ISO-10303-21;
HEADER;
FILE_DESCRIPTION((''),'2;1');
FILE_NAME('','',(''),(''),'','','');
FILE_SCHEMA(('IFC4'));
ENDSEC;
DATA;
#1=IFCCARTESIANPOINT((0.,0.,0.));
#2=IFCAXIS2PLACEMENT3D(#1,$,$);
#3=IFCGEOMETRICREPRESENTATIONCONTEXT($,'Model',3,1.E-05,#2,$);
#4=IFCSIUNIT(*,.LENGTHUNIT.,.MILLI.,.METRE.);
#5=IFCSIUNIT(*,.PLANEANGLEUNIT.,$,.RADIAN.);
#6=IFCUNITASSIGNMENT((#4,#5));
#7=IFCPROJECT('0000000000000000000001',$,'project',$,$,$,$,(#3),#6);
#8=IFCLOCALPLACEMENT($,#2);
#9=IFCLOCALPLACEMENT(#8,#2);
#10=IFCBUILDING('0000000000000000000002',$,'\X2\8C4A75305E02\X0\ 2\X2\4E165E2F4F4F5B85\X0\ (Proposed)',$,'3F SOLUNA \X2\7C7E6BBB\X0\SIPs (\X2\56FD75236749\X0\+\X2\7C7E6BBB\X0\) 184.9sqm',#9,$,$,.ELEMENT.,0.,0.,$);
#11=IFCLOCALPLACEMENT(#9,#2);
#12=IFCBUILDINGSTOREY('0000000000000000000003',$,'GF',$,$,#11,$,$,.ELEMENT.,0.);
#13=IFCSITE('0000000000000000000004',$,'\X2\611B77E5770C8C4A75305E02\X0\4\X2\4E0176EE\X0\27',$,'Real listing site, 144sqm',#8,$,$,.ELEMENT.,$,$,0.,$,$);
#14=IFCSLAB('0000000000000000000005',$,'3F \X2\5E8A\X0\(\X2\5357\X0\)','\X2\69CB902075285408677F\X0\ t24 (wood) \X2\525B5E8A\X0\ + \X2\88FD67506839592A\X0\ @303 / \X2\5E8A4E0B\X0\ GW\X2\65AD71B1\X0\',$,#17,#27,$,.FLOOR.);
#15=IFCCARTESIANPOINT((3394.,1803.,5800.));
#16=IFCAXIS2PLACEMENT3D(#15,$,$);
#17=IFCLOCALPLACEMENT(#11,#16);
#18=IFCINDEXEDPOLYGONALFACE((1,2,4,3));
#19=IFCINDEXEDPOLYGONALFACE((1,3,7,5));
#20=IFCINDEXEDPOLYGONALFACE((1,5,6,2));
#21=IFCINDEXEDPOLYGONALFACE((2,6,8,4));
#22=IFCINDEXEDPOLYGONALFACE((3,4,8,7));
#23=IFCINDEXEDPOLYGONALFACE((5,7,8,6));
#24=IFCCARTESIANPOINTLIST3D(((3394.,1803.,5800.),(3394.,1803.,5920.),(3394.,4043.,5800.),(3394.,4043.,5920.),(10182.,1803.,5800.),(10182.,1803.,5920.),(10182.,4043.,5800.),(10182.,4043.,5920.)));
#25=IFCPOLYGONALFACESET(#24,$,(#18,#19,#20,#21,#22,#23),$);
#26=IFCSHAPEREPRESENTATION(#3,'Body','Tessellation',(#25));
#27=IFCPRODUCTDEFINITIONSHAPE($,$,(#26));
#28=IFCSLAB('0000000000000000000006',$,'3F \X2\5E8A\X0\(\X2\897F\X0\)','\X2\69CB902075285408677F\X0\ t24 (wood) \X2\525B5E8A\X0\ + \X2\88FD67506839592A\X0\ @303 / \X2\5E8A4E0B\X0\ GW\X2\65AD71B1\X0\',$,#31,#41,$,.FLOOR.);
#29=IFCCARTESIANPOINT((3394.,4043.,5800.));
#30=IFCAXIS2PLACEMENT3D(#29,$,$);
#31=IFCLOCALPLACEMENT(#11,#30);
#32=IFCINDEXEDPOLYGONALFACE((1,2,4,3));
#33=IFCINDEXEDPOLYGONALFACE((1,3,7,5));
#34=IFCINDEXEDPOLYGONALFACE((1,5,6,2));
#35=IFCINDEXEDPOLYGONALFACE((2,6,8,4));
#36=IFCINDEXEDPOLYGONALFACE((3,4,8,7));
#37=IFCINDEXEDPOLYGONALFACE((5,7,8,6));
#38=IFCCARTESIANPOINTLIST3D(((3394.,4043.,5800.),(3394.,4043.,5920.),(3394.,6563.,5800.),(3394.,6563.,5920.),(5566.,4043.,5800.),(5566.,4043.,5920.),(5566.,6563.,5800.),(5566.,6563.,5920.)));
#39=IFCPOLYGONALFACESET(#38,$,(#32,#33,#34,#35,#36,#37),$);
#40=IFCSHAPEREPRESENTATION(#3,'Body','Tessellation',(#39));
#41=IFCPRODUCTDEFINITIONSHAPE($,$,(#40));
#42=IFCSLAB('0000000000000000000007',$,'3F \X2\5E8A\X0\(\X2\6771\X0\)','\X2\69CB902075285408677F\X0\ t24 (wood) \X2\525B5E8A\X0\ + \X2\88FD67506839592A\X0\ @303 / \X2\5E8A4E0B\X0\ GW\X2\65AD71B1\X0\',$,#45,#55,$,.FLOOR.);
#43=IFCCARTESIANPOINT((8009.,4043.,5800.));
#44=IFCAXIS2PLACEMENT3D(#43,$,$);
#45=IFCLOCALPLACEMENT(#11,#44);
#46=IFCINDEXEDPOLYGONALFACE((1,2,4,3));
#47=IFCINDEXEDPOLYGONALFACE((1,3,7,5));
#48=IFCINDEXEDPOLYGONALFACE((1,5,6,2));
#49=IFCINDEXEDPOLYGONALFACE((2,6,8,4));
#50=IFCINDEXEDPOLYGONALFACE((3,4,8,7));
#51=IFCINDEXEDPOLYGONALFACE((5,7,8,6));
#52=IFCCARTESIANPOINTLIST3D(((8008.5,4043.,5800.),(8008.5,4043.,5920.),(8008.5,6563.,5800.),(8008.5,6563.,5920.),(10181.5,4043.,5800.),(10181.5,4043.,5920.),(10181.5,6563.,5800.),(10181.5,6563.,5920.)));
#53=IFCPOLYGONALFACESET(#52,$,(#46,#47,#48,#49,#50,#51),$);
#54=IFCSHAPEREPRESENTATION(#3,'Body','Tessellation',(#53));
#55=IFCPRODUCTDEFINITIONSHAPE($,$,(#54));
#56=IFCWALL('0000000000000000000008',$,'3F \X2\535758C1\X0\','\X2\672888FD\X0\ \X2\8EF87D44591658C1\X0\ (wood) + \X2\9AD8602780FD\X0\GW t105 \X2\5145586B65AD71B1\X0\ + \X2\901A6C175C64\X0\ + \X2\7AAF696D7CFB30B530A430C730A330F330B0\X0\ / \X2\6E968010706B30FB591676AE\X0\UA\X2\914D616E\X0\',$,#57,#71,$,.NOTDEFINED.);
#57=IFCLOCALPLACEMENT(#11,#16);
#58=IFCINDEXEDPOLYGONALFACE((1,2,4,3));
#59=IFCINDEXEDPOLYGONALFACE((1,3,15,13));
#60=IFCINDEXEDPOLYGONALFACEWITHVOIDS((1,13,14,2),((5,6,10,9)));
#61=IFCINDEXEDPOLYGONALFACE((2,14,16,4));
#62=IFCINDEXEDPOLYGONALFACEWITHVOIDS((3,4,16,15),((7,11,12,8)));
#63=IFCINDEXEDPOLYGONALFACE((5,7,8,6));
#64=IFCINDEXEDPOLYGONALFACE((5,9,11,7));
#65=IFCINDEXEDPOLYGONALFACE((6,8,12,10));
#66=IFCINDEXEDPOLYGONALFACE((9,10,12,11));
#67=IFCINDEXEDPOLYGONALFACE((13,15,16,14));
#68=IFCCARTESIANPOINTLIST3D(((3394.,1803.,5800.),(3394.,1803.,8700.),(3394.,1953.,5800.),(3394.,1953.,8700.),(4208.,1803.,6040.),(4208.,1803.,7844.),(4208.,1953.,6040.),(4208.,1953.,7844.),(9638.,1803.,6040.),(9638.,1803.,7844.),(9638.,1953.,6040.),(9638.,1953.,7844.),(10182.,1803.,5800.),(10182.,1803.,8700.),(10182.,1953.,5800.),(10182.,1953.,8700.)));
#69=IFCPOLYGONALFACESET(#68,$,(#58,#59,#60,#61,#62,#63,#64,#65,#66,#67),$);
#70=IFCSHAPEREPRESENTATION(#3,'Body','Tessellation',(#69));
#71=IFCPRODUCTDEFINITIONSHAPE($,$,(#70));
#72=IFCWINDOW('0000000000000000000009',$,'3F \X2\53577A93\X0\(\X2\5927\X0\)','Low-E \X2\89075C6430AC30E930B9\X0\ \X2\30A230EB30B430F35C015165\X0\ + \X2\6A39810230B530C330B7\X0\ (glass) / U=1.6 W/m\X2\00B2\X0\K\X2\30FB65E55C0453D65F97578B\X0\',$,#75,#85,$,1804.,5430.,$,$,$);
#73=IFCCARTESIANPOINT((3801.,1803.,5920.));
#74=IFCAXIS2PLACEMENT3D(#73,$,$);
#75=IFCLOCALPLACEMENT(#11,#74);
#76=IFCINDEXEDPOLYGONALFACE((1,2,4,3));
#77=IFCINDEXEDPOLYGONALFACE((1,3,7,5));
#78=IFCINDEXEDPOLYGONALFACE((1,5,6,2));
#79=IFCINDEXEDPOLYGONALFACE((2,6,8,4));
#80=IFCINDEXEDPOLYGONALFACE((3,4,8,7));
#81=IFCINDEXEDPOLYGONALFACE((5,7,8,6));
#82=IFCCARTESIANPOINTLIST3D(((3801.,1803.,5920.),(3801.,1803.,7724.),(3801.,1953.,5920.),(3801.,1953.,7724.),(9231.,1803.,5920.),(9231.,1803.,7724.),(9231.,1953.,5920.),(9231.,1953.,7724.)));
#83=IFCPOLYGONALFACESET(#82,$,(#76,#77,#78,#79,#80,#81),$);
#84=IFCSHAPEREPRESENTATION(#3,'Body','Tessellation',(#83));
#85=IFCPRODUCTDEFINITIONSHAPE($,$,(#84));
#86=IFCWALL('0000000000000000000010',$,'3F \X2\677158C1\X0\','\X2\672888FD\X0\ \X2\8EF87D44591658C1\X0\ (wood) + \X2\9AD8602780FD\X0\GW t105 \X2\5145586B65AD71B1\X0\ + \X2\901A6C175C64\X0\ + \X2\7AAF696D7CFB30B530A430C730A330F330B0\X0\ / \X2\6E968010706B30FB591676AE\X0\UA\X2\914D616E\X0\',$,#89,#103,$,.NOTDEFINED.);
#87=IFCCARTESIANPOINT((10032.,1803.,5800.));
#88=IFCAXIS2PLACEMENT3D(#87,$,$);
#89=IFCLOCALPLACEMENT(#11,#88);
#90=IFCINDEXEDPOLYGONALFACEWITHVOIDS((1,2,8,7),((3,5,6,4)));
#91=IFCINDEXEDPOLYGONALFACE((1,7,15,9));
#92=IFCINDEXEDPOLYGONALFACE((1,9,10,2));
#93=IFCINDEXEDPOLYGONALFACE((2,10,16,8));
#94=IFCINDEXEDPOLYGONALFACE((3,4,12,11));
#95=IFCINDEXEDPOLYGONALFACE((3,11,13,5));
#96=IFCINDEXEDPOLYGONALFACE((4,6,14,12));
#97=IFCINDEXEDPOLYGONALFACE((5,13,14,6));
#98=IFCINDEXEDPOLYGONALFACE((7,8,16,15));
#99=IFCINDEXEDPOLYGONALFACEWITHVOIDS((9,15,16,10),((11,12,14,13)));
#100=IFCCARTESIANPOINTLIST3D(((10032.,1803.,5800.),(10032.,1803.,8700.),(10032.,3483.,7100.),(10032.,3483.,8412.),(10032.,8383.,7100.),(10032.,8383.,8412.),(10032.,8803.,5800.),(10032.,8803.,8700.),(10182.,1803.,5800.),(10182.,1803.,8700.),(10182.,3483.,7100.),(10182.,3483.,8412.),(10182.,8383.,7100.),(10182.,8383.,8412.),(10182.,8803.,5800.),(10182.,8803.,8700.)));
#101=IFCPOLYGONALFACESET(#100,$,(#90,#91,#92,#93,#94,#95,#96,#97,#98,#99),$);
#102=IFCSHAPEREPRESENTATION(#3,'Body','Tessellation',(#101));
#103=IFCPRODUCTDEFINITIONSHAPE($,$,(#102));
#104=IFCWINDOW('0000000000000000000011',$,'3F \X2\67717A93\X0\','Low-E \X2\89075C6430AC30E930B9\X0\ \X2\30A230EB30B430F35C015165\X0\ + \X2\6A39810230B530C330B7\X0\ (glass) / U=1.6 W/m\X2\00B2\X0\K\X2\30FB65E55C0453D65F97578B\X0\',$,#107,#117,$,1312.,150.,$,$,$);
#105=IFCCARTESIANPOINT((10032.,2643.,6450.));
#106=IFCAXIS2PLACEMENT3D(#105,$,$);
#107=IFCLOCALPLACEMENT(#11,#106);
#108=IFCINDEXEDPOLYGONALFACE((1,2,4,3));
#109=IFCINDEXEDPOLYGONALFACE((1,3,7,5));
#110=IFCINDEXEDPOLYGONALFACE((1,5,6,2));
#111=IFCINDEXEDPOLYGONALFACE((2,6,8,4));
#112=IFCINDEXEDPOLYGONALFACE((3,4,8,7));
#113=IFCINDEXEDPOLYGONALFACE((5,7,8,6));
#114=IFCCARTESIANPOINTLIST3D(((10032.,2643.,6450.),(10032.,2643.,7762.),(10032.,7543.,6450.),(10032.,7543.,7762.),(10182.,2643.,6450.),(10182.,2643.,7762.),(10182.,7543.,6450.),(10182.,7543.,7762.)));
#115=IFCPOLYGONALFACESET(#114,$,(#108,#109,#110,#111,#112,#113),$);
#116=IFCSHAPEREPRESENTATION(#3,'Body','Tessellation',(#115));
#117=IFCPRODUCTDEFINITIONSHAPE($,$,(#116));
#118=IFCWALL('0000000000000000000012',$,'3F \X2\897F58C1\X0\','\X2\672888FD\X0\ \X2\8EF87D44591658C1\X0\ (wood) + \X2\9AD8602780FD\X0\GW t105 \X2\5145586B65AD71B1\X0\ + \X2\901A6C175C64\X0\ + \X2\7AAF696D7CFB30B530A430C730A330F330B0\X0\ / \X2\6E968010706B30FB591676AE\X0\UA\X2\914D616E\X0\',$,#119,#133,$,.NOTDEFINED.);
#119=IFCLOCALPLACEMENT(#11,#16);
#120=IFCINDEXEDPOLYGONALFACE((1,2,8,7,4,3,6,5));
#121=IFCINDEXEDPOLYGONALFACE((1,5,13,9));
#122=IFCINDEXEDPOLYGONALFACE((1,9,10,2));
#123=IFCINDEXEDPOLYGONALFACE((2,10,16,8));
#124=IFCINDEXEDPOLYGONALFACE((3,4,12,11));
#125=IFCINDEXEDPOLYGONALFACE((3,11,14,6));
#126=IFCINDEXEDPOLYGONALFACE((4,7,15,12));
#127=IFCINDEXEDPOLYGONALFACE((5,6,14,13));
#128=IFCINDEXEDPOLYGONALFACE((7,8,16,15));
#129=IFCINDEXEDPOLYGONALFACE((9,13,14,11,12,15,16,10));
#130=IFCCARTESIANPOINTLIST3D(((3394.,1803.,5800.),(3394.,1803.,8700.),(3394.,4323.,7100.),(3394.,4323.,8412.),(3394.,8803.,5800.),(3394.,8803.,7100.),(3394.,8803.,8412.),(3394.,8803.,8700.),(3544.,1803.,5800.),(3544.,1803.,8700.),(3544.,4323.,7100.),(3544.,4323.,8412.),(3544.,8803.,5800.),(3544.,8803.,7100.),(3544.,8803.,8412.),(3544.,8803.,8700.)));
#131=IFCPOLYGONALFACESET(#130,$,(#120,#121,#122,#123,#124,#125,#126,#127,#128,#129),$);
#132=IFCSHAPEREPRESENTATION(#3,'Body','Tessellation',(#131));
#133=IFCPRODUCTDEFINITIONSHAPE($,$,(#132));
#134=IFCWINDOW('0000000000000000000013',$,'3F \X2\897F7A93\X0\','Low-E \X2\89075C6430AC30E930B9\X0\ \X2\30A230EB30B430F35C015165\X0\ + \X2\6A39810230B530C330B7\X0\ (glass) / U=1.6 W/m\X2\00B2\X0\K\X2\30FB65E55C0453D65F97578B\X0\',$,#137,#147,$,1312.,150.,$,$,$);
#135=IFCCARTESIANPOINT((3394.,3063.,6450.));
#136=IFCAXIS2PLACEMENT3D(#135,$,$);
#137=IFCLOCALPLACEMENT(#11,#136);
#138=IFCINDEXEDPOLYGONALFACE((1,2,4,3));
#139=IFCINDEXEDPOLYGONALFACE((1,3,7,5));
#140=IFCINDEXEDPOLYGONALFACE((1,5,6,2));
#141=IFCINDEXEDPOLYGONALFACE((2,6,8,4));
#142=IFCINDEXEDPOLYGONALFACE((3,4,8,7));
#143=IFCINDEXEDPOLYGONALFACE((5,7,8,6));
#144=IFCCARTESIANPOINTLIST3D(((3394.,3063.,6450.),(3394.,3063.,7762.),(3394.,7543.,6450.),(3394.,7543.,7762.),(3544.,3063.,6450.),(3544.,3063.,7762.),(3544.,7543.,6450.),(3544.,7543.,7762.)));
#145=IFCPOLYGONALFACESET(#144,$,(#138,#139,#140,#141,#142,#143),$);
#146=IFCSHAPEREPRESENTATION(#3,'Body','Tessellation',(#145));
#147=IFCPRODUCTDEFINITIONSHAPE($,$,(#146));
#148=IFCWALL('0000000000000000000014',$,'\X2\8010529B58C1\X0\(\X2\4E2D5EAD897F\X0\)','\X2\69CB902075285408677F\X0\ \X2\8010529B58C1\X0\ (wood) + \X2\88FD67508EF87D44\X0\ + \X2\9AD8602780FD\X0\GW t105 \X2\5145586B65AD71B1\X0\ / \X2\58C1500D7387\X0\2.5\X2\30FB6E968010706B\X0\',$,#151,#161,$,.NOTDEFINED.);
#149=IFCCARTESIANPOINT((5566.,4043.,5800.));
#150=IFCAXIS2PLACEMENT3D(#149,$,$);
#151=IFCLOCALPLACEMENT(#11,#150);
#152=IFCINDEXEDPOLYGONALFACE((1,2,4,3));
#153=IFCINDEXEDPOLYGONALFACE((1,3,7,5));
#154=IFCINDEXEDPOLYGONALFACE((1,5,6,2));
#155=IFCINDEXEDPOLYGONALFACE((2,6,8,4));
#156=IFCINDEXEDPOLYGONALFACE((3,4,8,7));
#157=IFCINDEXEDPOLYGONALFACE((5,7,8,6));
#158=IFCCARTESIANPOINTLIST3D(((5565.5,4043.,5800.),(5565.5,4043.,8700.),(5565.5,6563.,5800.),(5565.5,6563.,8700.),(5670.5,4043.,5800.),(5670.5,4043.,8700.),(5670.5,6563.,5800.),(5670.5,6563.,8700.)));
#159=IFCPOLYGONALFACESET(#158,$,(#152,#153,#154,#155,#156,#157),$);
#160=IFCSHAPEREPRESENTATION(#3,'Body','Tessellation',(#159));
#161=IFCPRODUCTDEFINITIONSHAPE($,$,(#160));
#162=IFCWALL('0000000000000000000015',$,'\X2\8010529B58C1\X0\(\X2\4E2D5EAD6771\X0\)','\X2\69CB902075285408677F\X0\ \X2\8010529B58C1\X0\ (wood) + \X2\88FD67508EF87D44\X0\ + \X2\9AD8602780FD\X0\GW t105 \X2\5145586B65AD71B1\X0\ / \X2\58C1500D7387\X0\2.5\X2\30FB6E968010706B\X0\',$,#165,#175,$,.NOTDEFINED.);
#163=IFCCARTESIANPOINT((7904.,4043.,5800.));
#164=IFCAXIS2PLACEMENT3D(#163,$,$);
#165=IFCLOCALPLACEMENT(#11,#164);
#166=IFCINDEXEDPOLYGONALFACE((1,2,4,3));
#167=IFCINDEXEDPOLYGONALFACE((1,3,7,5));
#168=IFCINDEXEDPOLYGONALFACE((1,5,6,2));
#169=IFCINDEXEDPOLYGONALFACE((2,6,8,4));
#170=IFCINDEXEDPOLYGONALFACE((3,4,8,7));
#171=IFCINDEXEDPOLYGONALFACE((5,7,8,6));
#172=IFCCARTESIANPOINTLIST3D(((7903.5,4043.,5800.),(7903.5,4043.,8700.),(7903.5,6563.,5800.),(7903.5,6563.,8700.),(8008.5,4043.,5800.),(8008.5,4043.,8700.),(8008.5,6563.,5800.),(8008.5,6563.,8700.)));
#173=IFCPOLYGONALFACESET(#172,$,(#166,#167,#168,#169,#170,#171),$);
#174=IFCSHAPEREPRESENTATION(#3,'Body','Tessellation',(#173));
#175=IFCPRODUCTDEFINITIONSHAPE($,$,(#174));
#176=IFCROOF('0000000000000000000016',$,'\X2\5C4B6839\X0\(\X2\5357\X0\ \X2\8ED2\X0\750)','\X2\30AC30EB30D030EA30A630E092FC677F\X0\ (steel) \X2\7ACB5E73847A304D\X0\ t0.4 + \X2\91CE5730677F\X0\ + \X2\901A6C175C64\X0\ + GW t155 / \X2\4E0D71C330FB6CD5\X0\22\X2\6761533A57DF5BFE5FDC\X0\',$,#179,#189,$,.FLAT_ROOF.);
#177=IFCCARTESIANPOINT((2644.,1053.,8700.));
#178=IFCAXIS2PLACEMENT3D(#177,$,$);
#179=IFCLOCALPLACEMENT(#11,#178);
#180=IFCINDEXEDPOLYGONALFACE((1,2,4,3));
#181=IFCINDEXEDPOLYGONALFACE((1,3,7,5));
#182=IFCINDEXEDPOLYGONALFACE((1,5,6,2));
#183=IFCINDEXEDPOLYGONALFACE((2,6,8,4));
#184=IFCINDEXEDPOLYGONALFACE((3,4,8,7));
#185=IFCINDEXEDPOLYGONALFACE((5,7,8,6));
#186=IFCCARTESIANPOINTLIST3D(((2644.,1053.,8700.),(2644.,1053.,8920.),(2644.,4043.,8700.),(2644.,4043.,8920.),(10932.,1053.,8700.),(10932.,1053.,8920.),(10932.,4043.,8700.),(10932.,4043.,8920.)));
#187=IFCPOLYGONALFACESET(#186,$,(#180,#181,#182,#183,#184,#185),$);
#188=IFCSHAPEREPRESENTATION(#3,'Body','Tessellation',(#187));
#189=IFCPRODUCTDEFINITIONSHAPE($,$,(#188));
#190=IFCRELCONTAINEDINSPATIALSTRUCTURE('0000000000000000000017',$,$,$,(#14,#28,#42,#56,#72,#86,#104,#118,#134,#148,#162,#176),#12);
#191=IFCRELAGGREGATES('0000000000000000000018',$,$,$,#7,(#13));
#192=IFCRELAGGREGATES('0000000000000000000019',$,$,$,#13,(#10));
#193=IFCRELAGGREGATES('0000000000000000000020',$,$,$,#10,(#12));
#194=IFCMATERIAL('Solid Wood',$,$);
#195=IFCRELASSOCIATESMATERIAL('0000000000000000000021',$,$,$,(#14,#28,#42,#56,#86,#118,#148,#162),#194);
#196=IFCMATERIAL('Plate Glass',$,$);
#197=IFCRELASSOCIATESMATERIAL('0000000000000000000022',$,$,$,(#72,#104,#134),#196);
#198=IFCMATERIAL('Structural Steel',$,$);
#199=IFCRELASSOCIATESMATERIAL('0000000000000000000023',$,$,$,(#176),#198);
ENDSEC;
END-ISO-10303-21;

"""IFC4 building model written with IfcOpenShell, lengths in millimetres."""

from ifc_helpers import new_model, si_unit, frame, frame_2d, origin, place, context, project, spatial, rectangle, extrude, material, element, fill, save


model = new_model("IFC4")

# Units and contexts
model_context = context("Model", 3, precision=1e-05, world=origin())
ifc_project = project(units=[si_unit("LENGTHUNIT", "METRE", prefix="MILLI"), si_unit("PLANEANGLEUNIT", "RADIAN")], contexts=[model_context])

# Site, building, storey
site_placement = place(None, origin())
site = spatial("IfcSite", under=ifc_project, at=site_placement, Name="愛知県豊田市4丁目27", ObjectType="Real listing site, 144sqm", CompositionType="ELEMENT", RefElevation=0.0)
building_placement = place(site_placement, origin())
building = spatial("IfcBuilding", under=site, at=building_placement, Name="豊田市 2世帯住宅 (Proposed)", ObjectType="3F SOLUNA 籾殻SIPs (国産杉+籾殻) 184.9sqm", CompositionType="ELEMENT", ElevationOfRefHeight=0.0, ElevationOfTerrain=0.0)
storey_placement = place(building_placement, origin())
storey = spatial("IfcBuildingStorey", under=building, at=storey_placement, Name="GF", CompositionType="ELEMENT", Elevation=0.0)

# Slabs
ifc_material_1 = material(Name="Solid Wood")
slab_1_placement = place(storey_placement, frame((3394.0, 1803.0, 5800.0)))
element("IfcSlab", 1, at=slab_1_placement, inside=storey, material=ifc_material_1, Name="3F 床(南)", Description="構造用合板 t24 (wood) 剛床 + 製材根太 @303 / 床下 GW断熱", PredefinedType="FLOOR", context=model_context, shape_type="SweptSolid", body=[
    extrude(rectangle(XDim=6788.0, YDim=2240.0, at=frame_2d((3394.0, 1120.0))), frame((3394.0, 1803.0, 5800.0)), (0.0, 0.0, 1.0), 120.0),
])
slab_2_placement = place(storey_placement, frame((3394.0, 4043.0, 5800.0)))
element("IfcSlab", 2, at=slab_2_placement, inside=storey, material=ifc_material_1, Name="3F 床(西)", Description="構造用合板 t24 (wood) 剛床 + 製材根太 @303 / 床下 GW断熱", PredefinedType="FLOOR", context=model_context, shape_type="SweptSolid", body=[
    extrude(rectangle(XDim=2172.0, YDim=2520.0, at=frame_2d((1086.0, 1260.0))), frame((3394.0, 4043.0, 5800.0)), (0.0, 0.0, 1.0), 120.0),
])
slab_3_placement = place(storey_placement, frame((8009.0, 4043.0, 5800.0)))
element("IfcSlab", 3, at=slab_3_placement, inside=storey, material=ifc_material_1, Name="3F 床(東)", Description="構造用合板 t24 (wood) 剛床 + 製材根太 @303 / 床下 GW断熱", PredefinedType="FLOOR", context=model_context, shape_type="SweptSolid", body=[
    extrude(rectangle(XDim=2173.0, YDim=2520.0, at=frame_2d((1086.0, 1260.0))), frame((8009.0, 4043.0, 5800.0)), (0.0, 0.0, 1.0), 120.0),
])

# Walls, openings, windows
wall_1_placement = place(storey_placement, frame((3394.0, 1803.0, 5800.0)))
wall_1 = element("IfcWall", 4, at=wall_1_placement, inside=storey, material=ifc_material_1, Name="3F 南壁", Description="木製 軸組外壁 (wood) + 高性能GW t105 充填断熱 + 通気層 + 窯業系サイディング / 準耐火・外皮UA配慮", PredefinedType="NOTDEFINED", context=model_context, shape_type="SweptSolid", body=[
    extrude(rectangle(XDim=6788.0, YDim=150.0, at=frame_2d((3394.0, 75.0))), frame((3394.0, 1803.0, 5800.0)), (0.0, 0.0, 1.0), 2900.0),
])
opening_1_placement = place(storey_placement, frame((3801.0, 1803.0, 5920.0)))
opening_1 = element("IfcOpeningElement", 5, at=opening_1_placement, cuts=wall_1, PredefinedType="NOTDEFINED", context=model_context, shape_type="SweptSolid", body=[
    extrude(rectangle(XDim=5430.0, YDim=150.0, at=frame_2d((2715.0, 75.0))), frame((3801.0, 1803.0, 5920.0)), (0.0, 0.0, 1.0), 1804.0),
])
ifc_material_2 = material(Name="Plate Glass")
window_1_placement = place(storey_placement, frame((3801.0, 1803.0, 5920.0)))
window_1 = element("IfcWindow", 6, at=window_1_placement, inside=storey, material=ifc_material_2, Name="3F 南窓(大)", Description="Low-E 複層ガラス アルゴン封入 + 樹脂サッシ (glass) / U=1.6 W/m²K・日射取得型", OverallHeight=1804.0, OverallWidth=5430.0, context=model_context, shape_type="SweptSolid", body=[
    extrude(rectangle(XDim=5430.0, YDim=150.0, at=frame_2d((2715.0, 75.0))), frame((3801.0, 1803.0, 5920.0)), (0.0, 0.0, 1.0), 1804.0),
])
fill(opening_1, window_1)
wall_2_placement = place(storey_placement, frame((10032.0, 1803.0, 5800.0)))
wall_2 = element("IfcWall", 7, at=wall_2_placement, inside=storey, material=ifc_material_1, Name="3F 東壁", Description="木製 軸組外壁 (wood) + 高性能GW t105 充填断熱 + 通気層 + 窯業系サイディング / 準耐火・外皮UA配慮", PredefinedType="NOTDEFINED", context=model_context, shape_type="SweptSolid", body=[
    extrude(rectangle(XDim=150.0, YDim=7000.0, at=frame_2d((75.0, 3500.0))), frame((10032.0, 1803.0, 5800.0)), (0.0, 0.0, 1.0), 2900.0),
])
opening_2_placement = place(storey_placement, frame((10032.0, 2643.0, 6450.0)))
opening_2 = element("IfcOpeningElement", 8, at=opening_2_placement, cuts=wall_2, PredefinedType="NOTDEFINED", context=model_context, shape_type="SweptSolid", body=[
    extrude(rectangle(XDim=150.0, YDim=4900.0, at=frame_2d((75.0, 2450.0))), frame((10032.0, 2643.0, 6450.0)), (0.0, 0.0, 1.0), 1312.0),
])
window_2_placement = place(storey_placement, frame((10032.0, 2643.0, 6450.0)))
window_2 = element("IfcWindow", 9, at=window_2_placement, inside=storey, material=ifc_material_2, Name="3F 東窓", Description="Low-E 複層ガラス アルゴン封入 + 樹脂サッシ (glass) / U=1.6 W/m²K・日射取得型", OverallHeight=1312.0, OverallWidth=150.0, context=model_context, shape_type="SweptSolid", body=[
    extrude(rectangle(XDim=150.0, YDim=4900.0, at=frame_2d((75.0, 2450.0))), frame((10032.0, 2643.0, 6450.0)), (0.0, 0.0, 1.0), 1312.0),
])
fill(opening_2, window_2)
wall_3_placement = place(storey_placement, frame((3394.0, 1803.0, 5800.0)))
wall_3 = element("IfcWall", 10, at=wall_3_placement, inside=storey, material=ifc_material_1, Name="3F 西壁", Description="木製 軸組外壁 (wood) + 高性能GW t105 充填断熱 + 通気層 + 窯業系サイディング / 準耐火・外皮UA配慮", PredefinedType="NOTDEFINED", context=model_context, shape_type="SweptSolid", body=[
    extrude(rectangle(XDim=150.0, YDim=7000.0, at=frame_2d((75.0, 3500.0))), frame((3394.0, 1803.0, 5800.0)), (0.0, 0.0, 1.0), 2900.0),
])
opening_3_placement = place(storey_placement, frame((3394.0, 3063.0, 6450.0)))
opening_3 = element("IfcOpeningElement", 11, at=opening_3_placement, cuts=wall_3, PredefinedType="NOTDEFINED", context=model_context, shape_type="SweptSolid", body=[
    extrude(rectangle(XDim=150.0, YDim=4480.0, at=frame_2d((75.0, 2240.0))), frame((3394.0, 3063.0, 6450.0)), (0.0, 0.0, 1.0), 1312.0),
])
window_3_placement = place(storey_placement, frame((3394.0, 3063.0, 6450.0)))
window_3 = element("IfcWindow", 12, at=window_3_placement, inside=storey, material=ifc_material_2, Name="3F 西窓", Description="Low-E 複層ガラス アルゴン封入 + 樹脂サッシ (glass) / U=1.6 W/m²K・日射取得型", OverallHeight=1312.0, OverallWidth=150.0, context=model_context, shape_type="SweptSolid", body=[
    extrude(rectangle(XDim=150.0, YDim=4480.0, at=frame_2d((75.0, 2240.0))), frame((3394.0, 3063.0, 6450.0)), (0.0, 0.0, 1.0), 1312.0),
])
fill(opening_3, window_3)

# Walls
wall_4_placement = place(storey_placement, frame((5566.0, 4043.0, 5800.0)))
element("IfcWall", 13, at=wall_4_placement, inside=storey, material=ifc_material_1, Name="耐力壁(中庭西)", Description="構造用合板 耐力壁 (wood) + 製材軸組 + 高性能GW t105 充填断熱 / 壁倍率2.5・準耐火", PredefinedType="NOTDEFINED", context=model_context, shape_type="SweptSolid", body=[
    extrude(rectangle(XDim=105.0, YDim=2520.0, at=frame_2d((52.0, 1260.0))), frame((5566.0, 4043.0, 5800.0)), (0.0, 0.0, 1.0), 2900.0),
])
wall_5_placement = place(storey_placement, frame((7904.0, 4043.0, 5800.0)))
element("IfcWall", 14, at=wall_5_placement, inside=storey, material=ifc_material_1, Name="耐力壁(中庭東)", Description="構造用合板 耐力壁 (wood) + 製材軸組 + 高性能GW t105 充填断熱 / 壁倍率2.5・準耐火", PredefinedType="NOTDEFINED", context=model_context, shape_type="SweptSolid", body=[
    extrude(rectangle(XDim=105.0, YDim=2520.0, at=frame_2d((52.0, 1260.0))), frame((7904.0, 4043.0, 5800.0)), (0.0, 0.0, 1.0), 2900.0),
])

# Roof
ifc_material_3 = material(Name="Structural Steel")
roof_1_placement = place(storey_placement, frame((2644.0, 1053.0, 8700.0)))
element("IfcRoof", 15, at=roof_1_placement, inside=storey, material=ifc_material_3, Name="屋根(南 軒750)", Description="ガルバリウム鋼板 (steel) 立平葺き t0.4 + 野地板 + 通気層 + GW t155 / 不燃・法22条区域対応", PredefinedType="FLAT_ROOF", context=model_context, shape_type="SweptSolid", body=[
    extrude(rectangle(XDim=8288.0, YDim=2990.0, at=frame_2d((4144.0, 1495.0))), frame((2644.0, 1053.0, 8700.0)), (0.0, 0.0, 1.0), 220.0),
])

save(model, "model.ifc")
